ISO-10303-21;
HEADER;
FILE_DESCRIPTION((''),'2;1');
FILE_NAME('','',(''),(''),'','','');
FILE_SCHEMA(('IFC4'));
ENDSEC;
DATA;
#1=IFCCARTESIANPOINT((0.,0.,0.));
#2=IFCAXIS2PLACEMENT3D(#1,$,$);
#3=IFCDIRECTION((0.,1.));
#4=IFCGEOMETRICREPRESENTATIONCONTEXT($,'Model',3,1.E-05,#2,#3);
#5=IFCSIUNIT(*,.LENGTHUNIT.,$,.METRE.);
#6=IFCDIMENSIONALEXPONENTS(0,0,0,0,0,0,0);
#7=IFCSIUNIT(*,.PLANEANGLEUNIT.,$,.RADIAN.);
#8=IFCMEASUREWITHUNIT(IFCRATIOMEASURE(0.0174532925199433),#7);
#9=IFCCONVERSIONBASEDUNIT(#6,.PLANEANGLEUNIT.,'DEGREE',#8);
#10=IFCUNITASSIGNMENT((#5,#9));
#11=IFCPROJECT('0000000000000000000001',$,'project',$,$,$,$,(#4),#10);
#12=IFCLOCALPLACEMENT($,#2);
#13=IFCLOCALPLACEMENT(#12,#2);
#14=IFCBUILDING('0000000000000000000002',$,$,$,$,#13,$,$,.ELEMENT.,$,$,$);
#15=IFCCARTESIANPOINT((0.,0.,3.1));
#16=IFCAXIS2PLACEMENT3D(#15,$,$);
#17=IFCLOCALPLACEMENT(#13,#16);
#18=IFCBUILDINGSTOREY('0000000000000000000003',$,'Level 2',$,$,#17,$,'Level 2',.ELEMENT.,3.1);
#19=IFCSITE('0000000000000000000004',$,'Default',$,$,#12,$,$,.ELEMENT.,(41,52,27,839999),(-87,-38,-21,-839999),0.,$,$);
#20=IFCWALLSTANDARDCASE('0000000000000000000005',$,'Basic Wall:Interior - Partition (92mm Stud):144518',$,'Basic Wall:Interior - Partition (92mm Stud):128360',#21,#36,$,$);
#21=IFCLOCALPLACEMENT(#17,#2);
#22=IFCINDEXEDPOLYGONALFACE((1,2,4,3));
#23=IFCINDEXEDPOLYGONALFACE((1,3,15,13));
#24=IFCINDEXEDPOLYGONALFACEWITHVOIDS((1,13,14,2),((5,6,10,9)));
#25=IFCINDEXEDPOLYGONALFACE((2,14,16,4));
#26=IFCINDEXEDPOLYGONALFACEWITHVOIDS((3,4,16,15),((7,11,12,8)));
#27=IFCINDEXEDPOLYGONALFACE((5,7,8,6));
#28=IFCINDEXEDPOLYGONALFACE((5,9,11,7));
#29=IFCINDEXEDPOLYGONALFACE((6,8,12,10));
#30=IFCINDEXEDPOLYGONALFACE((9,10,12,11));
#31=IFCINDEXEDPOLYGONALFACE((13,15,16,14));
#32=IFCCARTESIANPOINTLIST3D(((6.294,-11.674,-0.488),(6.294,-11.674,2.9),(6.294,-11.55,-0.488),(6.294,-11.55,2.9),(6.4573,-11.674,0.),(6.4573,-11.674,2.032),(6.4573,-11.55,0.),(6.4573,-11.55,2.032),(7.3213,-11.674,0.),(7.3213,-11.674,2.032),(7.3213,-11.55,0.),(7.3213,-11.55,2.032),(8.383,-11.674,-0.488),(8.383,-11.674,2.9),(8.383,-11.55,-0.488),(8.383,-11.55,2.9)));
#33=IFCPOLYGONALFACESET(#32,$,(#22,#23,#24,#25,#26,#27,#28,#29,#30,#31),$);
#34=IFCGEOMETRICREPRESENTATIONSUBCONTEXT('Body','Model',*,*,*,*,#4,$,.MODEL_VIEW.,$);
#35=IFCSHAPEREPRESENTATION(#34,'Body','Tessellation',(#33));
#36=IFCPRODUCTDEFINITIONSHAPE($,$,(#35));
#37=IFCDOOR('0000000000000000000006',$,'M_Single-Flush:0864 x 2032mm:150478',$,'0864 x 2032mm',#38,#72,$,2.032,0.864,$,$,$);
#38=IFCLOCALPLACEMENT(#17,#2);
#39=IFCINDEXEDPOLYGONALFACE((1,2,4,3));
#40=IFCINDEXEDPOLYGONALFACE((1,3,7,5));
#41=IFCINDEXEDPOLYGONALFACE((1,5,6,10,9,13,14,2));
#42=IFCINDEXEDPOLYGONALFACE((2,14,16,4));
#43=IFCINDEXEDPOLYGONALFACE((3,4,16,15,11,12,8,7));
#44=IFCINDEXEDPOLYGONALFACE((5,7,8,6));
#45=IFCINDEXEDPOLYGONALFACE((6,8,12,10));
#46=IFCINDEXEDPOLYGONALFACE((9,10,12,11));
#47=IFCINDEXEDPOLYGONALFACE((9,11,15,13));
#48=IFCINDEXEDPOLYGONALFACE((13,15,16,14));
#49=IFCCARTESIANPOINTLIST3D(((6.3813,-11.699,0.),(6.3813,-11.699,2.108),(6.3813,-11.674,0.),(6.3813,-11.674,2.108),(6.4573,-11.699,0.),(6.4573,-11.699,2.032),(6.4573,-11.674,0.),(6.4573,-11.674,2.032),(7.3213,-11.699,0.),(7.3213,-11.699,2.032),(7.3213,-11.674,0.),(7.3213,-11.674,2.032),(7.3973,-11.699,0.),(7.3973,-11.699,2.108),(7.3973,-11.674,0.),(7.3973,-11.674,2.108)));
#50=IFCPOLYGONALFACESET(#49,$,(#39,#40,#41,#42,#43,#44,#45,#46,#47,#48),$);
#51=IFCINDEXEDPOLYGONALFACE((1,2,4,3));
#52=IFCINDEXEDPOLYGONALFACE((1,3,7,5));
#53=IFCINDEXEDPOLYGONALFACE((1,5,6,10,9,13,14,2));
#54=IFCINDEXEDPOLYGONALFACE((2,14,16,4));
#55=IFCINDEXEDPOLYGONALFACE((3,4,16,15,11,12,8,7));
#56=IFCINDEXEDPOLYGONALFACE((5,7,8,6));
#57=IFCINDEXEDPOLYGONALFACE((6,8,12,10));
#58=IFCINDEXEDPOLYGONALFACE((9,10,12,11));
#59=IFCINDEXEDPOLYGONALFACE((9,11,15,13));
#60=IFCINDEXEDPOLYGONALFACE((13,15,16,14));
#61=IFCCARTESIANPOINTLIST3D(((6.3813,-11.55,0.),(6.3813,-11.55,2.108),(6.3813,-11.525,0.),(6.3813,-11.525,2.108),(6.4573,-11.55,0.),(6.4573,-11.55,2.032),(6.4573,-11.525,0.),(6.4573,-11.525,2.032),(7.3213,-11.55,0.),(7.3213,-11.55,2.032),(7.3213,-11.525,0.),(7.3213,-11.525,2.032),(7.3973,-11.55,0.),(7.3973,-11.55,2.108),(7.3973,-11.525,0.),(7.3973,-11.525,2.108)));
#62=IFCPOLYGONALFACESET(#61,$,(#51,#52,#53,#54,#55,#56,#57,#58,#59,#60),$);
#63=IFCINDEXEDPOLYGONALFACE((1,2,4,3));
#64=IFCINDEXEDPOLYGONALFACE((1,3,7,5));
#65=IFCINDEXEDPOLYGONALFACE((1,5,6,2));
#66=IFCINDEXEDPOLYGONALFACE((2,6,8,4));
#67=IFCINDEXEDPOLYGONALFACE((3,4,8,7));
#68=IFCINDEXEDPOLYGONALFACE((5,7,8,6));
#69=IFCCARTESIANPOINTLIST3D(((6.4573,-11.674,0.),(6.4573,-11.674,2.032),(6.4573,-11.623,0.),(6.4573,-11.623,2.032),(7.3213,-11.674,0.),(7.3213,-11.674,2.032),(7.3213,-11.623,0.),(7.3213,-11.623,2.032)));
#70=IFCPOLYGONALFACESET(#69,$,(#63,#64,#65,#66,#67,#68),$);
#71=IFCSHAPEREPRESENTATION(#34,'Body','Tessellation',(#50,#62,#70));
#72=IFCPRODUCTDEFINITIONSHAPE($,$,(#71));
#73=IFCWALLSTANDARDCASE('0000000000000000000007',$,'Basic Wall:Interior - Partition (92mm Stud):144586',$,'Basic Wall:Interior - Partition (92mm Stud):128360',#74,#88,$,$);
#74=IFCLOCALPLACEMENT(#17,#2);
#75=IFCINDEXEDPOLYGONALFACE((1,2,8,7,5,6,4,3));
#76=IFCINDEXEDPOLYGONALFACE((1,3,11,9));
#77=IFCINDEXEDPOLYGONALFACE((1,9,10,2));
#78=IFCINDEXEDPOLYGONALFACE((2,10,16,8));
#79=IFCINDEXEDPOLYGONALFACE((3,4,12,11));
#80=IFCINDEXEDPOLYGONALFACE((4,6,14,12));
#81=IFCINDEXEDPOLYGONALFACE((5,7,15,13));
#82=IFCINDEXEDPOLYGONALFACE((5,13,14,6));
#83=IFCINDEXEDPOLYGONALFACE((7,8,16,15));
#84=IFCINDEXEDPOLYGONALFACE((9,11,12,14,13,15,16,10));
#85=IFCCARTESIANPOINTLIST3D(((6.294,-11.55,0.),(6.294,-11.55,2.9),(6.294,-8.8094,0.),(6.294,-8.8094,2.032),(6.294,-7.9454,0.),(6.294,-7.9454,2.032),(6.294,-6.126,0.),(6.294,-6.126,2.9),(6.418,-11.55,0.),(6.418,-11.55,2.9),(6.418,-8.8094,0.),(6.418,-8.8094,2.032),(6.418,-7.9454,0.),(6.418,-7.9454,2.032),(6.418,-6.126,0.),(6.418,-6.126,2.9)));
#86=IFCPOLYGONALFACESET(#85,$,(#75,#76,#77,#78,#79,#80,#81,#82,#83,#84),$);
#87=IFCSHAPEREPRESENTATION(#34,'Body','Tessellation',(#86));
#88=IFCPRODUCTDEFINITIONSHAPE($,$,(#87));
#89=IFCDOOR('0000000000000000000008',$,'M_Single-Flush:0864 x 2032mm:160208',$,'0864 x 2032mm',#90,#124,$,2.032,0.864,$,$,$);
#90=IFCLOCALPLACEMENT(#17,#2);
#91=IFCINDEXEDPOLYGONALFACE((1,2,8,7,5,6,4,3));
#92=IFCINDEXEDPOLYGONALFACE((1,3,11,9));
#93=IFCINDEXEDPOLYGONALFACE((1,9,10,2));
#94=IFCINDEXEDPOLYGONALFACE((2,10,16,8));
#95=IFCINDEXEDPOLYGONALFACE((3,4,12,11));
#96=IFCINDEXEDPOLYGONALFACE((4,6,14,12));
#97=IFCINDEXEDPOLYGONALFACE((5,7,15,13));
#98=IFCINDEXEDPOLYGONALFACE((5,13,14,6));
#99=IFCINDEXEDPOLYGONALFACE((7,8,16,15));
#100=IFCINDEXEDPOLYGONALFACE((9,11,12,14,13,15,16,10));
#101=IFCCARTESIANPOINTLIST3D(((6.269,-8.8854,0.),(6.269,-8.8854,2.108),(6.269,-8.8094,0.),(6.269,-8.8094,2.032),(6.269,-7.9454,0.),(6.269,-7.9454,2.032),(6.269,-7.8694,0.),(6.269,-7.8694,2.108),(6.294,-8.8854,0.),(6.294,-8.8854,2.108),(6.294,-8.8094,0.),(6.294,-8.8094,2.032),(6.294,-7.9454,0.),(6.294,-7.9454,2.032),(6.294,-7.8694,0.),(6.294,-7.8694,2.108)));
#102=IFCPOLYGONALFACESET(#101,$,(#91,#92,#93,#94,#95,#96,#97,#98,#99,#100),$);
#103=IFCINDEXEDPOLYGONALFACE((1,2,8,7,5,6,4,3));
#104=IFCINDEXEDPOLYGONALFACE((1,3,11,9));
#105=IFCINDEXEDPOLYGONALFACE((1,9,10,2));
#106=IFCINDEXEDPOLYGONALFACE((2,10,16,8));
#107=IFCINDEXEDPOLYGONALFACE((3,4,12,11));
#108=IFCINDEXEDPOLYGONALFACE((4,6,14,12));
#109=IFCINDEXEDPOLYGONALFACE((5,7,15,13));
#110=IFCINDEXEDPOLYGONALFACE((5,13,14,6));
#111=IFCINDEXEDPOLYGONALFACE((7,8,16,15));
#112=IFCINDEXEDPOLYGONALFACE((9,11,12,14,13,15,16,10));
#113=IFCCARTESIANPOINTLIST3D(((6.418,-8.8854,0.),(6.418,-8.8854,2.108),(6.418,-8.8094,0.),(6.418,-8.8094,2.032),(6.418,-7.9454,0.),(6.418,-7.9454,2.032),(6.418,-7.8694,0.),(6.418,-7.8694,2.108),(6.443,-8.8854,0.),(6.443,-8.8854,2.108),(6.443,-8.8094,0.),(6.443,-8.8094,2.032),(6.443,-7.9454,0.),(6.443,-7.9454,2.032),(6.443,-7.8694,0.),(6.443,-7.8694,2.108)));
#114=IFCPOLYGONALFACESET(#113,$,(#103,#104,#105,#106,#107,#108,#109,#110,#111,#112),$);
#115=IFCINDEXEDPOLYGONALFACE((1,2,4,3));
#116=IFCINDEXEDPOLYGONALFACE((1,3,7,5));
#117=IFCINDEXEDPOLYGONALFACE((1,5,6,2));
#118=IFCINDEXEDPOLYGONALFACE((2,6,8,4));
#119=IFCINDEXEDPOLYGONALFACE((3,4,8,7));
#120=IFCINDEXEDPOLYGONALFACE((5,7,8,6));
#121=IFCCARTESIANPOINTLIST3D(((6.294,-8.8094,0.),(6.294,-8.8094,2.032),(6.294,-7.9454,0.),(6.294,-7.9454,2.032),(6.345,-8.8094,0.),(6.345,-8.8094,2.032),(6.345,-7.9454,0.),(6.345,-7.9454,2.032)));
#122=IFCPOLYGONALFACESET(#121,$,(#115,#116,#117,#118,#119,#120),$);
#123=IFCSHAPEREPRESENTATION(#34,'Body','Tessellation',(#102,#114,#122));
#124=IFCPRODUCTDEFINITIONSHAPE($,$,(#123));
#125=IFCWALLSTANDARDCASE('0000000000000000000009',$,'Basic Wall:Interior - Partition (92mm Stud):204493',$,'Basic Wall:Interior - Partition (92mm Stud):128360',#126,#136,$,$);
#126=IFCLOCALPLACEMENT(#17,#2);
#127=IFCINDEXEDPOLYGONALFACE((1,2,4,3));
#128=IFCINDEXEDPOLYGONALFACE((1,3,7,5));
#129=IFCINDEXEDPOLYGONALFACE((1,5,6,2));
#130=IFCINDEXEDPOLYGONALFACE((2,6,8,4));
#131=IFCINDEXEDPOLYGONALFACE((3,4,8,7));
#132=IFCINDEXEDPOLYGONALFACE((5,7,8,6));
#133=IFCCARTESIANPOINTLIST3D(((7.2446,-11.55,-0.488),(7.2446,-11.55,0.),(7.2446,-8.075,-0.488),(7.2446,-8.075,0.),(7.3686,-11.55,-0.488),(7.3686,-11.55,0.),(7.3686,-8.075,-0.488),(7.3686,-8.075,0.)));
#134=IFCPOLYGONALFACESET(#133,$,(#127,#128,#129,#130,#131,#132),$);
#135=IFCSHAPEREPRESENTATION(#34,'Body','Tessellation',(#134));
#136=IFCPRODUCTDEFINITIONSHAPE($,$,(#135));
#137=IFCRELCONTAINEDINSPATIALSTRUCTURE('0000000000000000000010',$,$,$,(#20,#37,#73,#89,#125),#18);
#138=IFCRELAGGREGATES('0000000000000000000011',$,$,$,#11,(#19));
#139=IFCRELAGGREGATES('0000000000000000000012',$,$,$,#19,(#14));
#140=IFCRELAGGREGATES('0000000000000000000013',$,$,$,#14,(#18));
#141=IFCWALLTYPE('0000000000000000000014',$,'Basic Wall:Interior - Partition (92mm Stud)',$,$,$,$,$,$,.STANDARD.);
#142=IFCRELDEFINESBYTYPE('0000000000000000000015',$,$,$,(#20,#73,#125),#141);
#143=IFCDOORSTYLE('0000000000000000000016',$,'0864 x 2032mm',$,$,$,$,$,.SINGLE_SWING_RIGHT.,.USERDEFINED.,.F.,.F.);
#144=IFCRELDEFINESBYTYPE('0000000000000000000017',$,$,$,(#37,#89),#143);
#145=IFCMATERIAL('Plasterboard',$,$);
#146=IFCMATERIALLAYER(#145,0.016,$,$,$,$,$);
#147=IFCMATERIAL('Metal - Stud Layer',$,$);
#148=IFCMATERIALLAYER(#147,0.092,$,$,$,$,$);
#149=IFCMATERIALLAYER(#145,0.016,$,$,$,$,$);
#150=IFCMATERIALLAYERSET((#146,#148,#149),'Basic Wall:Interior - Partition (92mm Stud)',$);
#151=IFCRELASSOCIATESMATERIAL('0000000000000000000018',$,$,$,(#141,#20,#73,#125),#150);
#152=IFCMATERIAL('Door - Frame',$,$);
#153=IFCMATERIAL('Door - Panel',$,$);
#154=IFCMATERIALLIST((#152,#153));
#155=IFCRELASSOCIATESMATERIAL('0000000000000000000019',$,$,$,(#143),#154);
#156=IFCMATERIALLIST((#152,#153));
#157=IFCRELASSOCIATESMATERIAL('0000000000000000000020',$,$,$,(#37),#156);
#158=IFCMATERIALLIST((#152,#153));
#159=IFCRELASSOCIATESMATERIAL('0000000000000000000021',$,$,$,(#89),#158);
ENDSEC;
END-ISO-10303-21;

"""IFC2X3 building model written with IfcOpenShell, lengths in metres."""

from ifc_helpers import new_model, entity, si_unit, converted_unit, direction, frame, frame_2d, origin, origin_2d_with_axis, place, context, subcontext, project, spatial, polyline, rectangle, outline, extrude, source, transform, mapped, material, material_list, layer, layer_set, layer_usage, type_object, type_shapes, element, fill, save


model = new_model("IFC2X3")

# Units and contexts
model_context = context("Model", 3, precision=1e-05, world=origin(), true_north=direction((0.0, 1.0)))
body_context = subcontext(model_context, "Body", "Model", "MODEL_VIEW")
ifc_project = project(units=[si_unit("LENGTHUNIT", "METRE"), converted_unit("PLANEANGLEUNIT", "DEGREE", entity("IfcRatioMeasure", 0.0174532925199433), si_unit("PLANEANGLEUNIT", "RADIAN"), dimensions=[0, 0, 0, 0, 0, 0, 0])], contexts=[model_context])

# Site, building, storey
site_placement = place(None, origin())
site = spatial("IfcSite", under=ifc_project, at=site_placement, Name="Default", CompositionType="ELEMENT", RefLatitude=(41, 52, 27, 839999), RefLongitude=(-87, -38, -21, -839999), RefElevation=0.0)
building_placement = place(site_placement, origin())
building = spatial("IfcBuilding", under=site, at=building_placement, CompositionType="ELEMENT")
storey_placement = place(building_placement, frame((0.0, 0.0, 3.1)))
storey = spatial("IfcBuildingStorey", under=building, at=storey_placement, Name="Level 2", LongName="Level 2", CompositionType="ELEMENT", Elevation=3.1)

# Shared definitions
ifc_material_1 = material(Name="Metal - Stud Layer")
ifc_material_2 = material(Name="Plasterboard")

# Wall, opening, door
ifc_layer_1 = layer(ifc_material_2, 0.016)
ifc_layer_2 = layer(ifc_material_1, 0.092)
ifc_layer_3 = layer(ifc_material_2, 0.016)
ifc_layer_set_1 = layer_set([ifc_layer_1, ifc_layer_2, ifc_layer_3], Name="Basic Wall:Interior - Partition (92mm Stud)")
ifc_layer_usage_1 = layer_usage(ifc_layer_set_1, "AXIS2", "NEGATIVE", 0.062)
wall_type_1 = type_object("IfcWallType", Name="Basic Wall:Interior - Partition (92mm Stud)", PredefinedType="STANDARD", material=ifc_layer_set_1)
wall_1_placement = place(storey_placement, frame((8.383, -11.612, -0.488), z_axis=(0.0, 0.0, 1.0), x_axis=(-1.0, 0.0, 0.0)))
wall_1 = element("IfcWallStandardCase", 1, at=wall_1_placement, inside=storey, type_object=wall_type_1, material=ifc_layer_usage_1, Name="Basic Wall:Interior - Partition (92mm Stud):144518", ObjectType="Basic Wall:Interior - Partition (92mm Stud):128360", context=body_context, shape_type="SweptSolid", body=[
    extrude(rectangle(XDim=2.089, YDim=0.124, at=frame_2d((1.0445, 0.0), x_axis=(-1.0, 0.0))), origin(), (0.0, 0.0, 1.0), 3.388),
])
opening_1_placement = place(wall_1_placement, frame((1.0617, -0.062, 0.488)))
opening_1 = element("IfcOpeningElement", 2, at=opening_1_placement, cuts=wall_1, ObjectType="Opening", context=body_context, shape_type="SweptSolid", body=[
    extrude(rectangle(XDim=0.864, YDim=2.032, at=frame_2d((1.016, 0.432), x_axis=(0.0, 1.0))), frame((0.0, 0.0, 0.0), z_axis=(0.0, 1.0, 0.0), x_axis=(0.0, 0.0, 1.0)), (0.0, 0.0, 1.0), 0.124),
])
ifc_material_3 = material(Name="Door - Frame")
ifc_material_4 = material(Name="Door - Panel")
ifc_material_list_1 = material_list([ifc_material_3, ifc_material_4])
ifc_material_list_2 = material_list([ifc_material_3, ifc_material_4])
door_style = type_object("IfcDoorStyle", Name="0864 x 2032mm", ConstructionType="USERDEFINED", OperationType="SINGLE_SWING_RIGHT", ParameterTakesPrecedence=False, Sizeable=False, material=ifc_material_list_2)
shared_shape_1 = source(origin(), body_context, "Body", "SweptSolid", [
    extrude(outline(polyline([(-0.508, -1.073), (0.508, -1.073), (0.508, 1.035), (0.432, 1.035), (0.432, -0.997), (-0.432, -0.997), (-0.432, 1.035), (-0.508, 1.035), (-0.508, -1.073)])), frame((0.432, 0.124, 1.035), z_axis=(0.0, 1.0, 0.0), x_axis=(1.0, 0.0, 0.0)), (0.0, 0.0, 1.0), 0.025),
    extrude(outline(polyline([(-1.073, -0.508), (1.035, -0.508), (1.035, -0.432), (-0.997, -0.432), (-0.997, 0.432), (1.035, 0.432), (1.035, 0.508), (-1.073, 0.508), (-1.073, -0.508)])), frame((0.432, -0.025, 1.035), z_axis=(0.0, 1.0, 0.0), x_axis=(0.0, 0.0, -1.0)), (0.0, 0.0, 1.0), 0.025),
    extrude(rectangle(XDim=0.051, YDim=0.864, at=origin_2d_with_axis()), frame((0.432, 0.0985, 0.0), z_axis=(0.0, 0.0, 1.0), x_axis=(0.0, 1.0, 0.0)), (0.0, 0.0, 1.0), 2.032),
])
type_shapes(door_style, [shared_shape_1])
door_1_placement = place(opening_1_placement, origin())
door_1 = element("IfcDoor", 3, at=door_1_placement, inside=storey, type_object=door_style, material=ifc_material_list_1, Name="M_Single-Flush:0864 x 2032mm:150478", ObjectType="0864 x 2032mm", OverallHeight=2.032, OverallWidth=0.864, context=body_context, shape_type="MappedRepresentation", body=[
    mapped(shared_shape_1, transform((0.0, 0.0, 0.0), scale=1.0)),
])
fill(opening_1, door_1)

# Wall, openings, door
ifc_layer_usage_2 = layer_usage(ifc_layer_set_1, "AXIS2", "NEGATIVE", 0.062)
wall_2_placement = place(storey_placement, frame((6.356, -11.55, 0.0), z_axis=(0.0, 0.0, 1.0), x_axis=(0.0, 1.0, 0.0)))
wall_2 = element("IfcWallStandardCase", 4, at=wall_2_placement, inside=storey, type_object=wall_type_1, material=ifc_layer_usage_2, Name="Basic Wall:Interior - Partition (92mm Stud):144586", ObjectType="Basic Wall:Interior - Partition (92mm Stud):128360", context=body_context, shape_type="SweptSolid", body=[
    extrude(rectangle(XDim=5.424, YDim=0.124, at=frame_2d((2.712, 0.0), x_axis=(-1.0, 0.0))), origin(), (0.0, 0.0, 1.0), 2.9),
])
opening_2_placement = place(wall_2_placement, origin())
element("IfcOpeningElement", 5, at=opening_2_placement, cuts=wall_2, ObjectType="Opening", context=body_context, shape_type="SweptSolid", body=[
    extrude(rectangle(XDim=2.032, YDim=0.124, at=frame_2d((0.0, 0.0), x_axis=(0.0, 1.0))), frame((3.7666, 0.0626, 1.016), z_axis=(0.0, 1.0, 0.0), x_axis=(1.0, 0.0, 0.0)), (0.0, 0.0, 1.0), 0.762),
])
opening_3_placement = place(wall_2_placement, frame((2.7406, -0.062, 0.0)))
opening_3 = element("IfcOpeningElement", 6, at=opening_3_placement, cuts=wall_2, ObjectType="Opening", context=body_context, shape_type="SweptSolid", body=[
    extrude(rectangle(XDim=0.864, YDim=2.032, at=frame_2d((1.016, 0.432), x_axis=(0.0, 1.0))), frame((0.0, 0.0, 0.0), z_axis=(0.0, 1.0, 0.0), x_axis=(0.0, 0.0, 1.0)), (0.0, 0.0, 1.0), 0.124),
])
ifc_material_list_3 = material_list([ifc_material_3, ifc_material_4])
door_2_placement = place(opening_3_placement, origin())
door_2 = element("IfcDoor", 7, at=door_2_placement, inside=storey, type_object=door_style, material=ifc_material_list_3, Name="M_Single-Flush:0864 x 2032mm:160208", ObjectType="0864 x 2032mm", OverallHeight=2.032, OverallWidth=0.864, context=body_context, shape_type="MappedRepresentation", body=[
    mapped(shared_shape_1, transform((0.0, 0.0, 0.0), scale=1.0)),
])
fill(opening_3, door_2)

# Wall
ifc_layer_usage_3 = layer_usage(ifc_layer_set_1, "AXIS2", "NEGATIVE", 0.062)
wall_3_placement = place(storey_placement, frame((7.3066, -11.55, -0.488), z_axis=(0.0, 0.0, 1.0), x_axis=(0.0, 1.0, 0.0)))
element("IfcWallStandardCase", 8, at=wall_3_placement, inside=storey, type_object=wall_type_1, material=ifc_layer_usage_3, Name="Basic Wall:Interior - Partition (92mm Stud):204493", ObjectType="Basic Wall:Interior - Partition (92mm Stud):128360", context=body_context, shape_type="SweptSolid", body=[
    extrude(rectangle(XDim=3.475, YDim=0.124, at=frame_2d((1.7375, 0.0), x_axis=(-1.0, 0.0))), origin(), (0.0, 0.0, 1.0), 0.488),
])

save(model, "model.ifc")
